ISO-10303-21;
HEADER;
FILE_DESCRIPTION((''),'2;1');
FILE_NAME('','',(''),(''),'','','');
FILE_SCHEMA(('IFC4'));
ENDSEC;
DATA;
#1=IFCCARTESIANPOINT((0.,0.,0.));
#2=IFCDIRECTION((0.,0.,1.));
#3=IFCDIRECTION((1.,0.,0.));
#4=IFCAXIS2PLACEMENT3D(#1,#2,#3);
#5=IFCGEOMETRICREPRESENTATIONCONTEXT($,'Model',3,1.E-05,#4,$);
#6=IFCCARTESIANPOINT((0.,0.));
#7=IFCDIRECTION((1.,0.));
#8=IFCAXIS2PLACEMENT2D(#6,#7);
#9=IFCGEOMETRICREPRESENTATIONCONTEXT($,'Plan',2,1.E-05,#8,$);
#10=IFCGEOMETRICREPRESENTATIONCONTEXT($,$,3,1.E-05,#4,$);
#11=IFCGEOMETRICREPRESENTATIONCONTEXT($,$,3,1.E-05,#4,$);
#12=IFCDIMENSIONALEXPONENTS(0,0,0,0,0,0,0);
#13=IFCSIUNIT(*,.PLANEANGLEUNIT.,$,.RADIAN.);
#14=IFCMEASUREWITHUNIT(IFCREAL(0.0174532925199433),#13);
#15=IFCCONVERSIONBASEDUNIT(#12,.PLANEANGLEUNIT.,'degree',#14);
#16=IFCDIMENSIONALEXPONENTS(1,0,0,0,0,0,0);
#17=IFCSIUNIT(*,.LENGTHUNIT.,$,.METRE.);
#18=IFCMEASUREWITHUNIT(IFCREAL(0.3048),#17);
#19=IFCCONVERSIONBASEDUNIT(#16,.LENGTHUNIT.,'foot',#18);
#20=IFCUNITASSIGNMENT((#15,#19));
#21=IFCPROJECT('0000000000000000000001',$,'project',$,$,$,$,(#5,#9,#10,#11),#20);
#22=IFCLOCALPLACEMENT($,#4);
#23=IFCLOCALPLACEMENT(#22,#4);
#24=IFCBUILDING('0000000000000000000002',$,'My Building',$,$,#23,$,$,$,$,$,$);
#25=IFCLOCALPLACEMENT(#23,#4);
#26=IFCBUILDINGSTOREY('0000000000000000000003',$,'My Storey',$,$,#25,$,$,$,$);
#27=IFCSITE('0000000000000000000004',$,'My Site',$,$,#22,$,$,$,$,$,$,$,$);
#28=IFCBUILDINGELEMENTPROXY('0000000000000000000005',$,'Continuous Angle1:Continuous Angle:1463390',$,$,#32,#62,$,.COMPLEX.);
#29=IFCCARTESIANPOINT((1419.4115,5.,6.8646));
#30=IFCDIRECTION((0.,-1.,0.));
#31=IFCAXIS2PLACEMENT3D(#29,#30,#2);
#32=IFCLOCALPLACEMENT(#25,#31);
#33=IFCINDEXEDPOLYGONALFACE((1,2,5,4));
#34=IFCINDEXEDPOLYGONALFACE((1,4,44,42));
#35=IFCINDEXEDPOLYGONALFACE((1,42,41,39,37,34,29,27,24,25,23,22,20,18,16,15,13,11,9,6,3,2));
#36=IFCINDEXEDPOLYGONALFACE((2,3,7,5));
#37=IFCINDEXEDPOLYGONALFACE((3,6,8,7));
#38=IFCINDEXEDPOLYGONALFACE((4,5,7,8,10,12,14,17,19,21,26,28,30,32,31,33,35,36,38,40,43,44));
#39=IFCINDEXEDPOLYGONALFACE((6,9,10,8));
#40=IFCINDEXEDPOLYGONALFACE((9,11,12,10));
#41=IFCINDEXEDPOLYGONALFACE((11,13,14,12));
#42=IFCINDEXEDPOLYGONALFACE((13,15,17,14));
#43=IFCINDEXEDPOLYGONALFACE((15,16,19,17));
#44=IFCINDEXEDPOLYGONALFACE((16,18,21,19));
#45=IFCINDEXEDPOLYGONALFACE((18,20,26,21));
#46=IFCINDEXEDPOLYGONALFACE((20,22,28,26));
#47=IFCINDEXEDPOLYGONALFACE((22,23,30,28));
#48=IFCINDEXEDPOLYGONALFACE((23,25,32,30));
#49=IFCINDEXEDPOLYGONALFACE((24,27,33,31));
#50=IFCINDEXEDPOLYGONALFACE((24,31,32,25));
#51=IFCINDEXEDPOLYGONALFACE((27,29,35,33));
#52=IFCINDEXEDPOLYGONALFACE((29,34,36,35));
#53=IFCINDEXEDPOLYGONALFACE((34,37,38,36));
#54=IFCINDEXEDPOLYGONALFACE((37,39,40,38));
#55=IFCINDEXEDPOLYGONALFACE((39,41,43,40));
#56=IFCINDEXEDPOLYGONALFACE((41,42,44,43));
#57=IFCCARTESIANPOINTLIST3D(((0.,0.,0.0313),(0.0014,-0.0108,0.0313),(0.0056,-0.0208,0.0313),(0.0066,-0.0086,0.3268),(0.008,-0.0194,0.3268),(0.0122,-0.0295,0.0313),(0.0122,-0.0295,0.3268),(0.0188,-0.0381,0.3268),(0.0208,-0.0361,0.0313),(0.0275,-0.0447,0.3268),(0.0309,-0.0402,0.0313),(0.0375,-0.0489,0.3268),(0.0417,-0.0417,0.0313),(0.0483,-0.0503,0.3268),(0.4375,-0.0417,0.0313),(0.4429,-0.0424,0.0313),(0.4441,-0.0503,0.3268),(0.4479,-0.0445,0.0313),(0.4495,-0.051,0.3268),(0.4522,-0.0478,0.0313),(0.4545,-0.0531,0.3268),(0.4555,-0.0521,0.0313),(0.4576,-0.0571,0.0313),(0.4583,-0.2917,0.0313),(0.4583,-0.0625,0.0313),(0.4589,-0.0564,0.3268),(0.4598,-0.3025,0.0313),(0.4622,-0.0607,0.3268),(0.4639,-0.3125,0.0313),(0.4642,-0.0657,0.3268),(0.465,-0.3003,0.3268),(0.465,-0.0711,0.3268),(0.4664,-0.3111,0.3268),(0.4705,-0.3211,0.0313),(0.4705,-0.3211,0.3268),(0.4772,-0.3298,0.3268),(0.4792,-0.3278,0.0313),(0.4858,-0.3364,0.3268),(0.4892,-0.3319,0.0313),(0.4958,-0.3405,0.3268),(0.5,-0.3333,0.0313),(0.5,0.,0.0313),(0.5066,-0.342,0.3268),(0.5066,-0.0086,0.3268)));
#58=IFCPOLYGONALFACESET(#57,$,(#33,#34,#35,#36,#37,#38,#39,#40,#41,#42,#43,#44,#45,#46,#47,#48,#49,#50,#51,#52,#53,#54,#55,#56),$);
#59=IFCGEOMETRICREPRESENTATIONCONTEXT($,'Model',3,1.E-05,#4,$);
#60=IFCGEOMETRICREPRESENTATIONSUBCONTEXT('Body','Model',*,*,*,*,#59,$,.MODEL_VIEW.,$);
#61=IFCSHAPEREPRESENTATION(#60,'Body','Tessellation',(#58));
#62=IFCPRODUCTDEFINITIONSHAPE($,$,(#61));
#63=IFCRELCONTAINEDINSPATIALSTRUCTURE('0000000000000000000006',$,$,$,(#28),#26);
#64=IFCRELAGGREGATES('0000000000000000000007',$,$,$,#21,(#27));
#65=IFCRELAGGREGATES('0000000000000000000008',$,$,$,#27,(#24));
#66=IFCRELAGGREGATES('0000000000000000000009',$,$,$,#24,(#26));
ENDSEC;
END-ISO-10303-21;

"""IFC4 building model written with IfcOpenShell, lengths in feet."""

from ifc_helpers import new_model, entity, si_unit, converted_unit, frame, origin_with_axes, origin_2d_with_axis, place, context, subcontext, project, spatial, polyline, outline, extrude, element, save


model = new_model("IFC4")

# Units and contexts
model_context_1 = context("Model", 3, precision=1e-05, world=origin_with_axes())
plan_context = context("Plan", 2, precision=1e-05, world=origin_2d_with_axis())
model_context_2 = context("Model", 3, precision=1e-05, world=origin_with_axes())
context_of_model_1 = context(None, 3, precision=1e-05, world=origin_with_axes())
context_of_model_2 = context(None, 3, precision=1e-05, world=origin_with_axes())
body_context_1 = subcontext(model_context_2, "Body", "Model", "MODEL_VIEW")
ifc_project = project(units=[converted_unit("PLANEANGLEUNIT", "degree", entity("IfcReal", 0.0174532925199433), si_unit("PLANEANGLEUNIT", "RADIAN"), dimensions=[0, 0, 0, 0, 0, 0, 0]), converted_unit("LENGTHUNIT", "foot", entity("IfcReal", 0.3048), si_unit("LENGTHUNIT", "METRE"), dimensions=[1, 0, 0, 0, 0, 0, 0])], contexts=[model_context_1, plan_context, context_of_model_1, context_of_model_2])

# Site, building, storey
site_placement = place(None, origin_with_axes())
site = spatial("IfcSite", under=ifc_project, at=site_placement, Name="My Site")
building_placement = place(site_placement, origin_with_axes())
building = spatial("IfcBuilding", under=site, at=building_placement, Name="My Building")
storey_placement = place(building_placement, origin_with_axes())
storey = spatial("IfcBuildingStorey", under=building, at=storey_placement, Name="My Storey")

# Building element proxy
proxy_1_placement = place(storey_placement, frame((1419.4115, 5.0, 6.8646), z_axis=(0.0, -1.0, 0.0), x_axis=(0.0, 0.0, 1.0)))
element("IfcBuildingElementProxy", 1, at=proxy_1_placement, inside=storey, Name="Continuous Angle1:Continuous Angle:1463390", PredefinedType="COMPLEX", context=body_context_1, shape_type="SweptSolid", body=[
    extrude(outline(polyline([(0.2352, 0.0), (0.2247, -0.0027), (0.2152, -0.0081), (0.0324, -0.1463), (0.0277, -0.149), (0.0224, -0.1504), (0.017, -0.1503), (0.0117, -0.1489), (0.007, -0.1461), (0.0032, -0.1423), (-0.2355, 0.1735), (-0.2431, 0.1812), (-0.2525, 0.1867), (-0.263, 0.1896), (-0.2739, 0.1897), (-0.2844, 0.1869), (-0.2939, 0.1816), (0.0077, -0.2173), (0.2736, -0.0162), (0.2659, -0.0085), (0.2566, -0.003), (0.2461, -0.0001), (0.2352, 0.0)])), frame((0.3221, -0.1249, 0.0313), z_axis=(0.0, 0.0, -1.0), x_axis=(0.60311, -0.797658, 0.0)), (0.036779, -0.000261, -0.999323), 0.2957),
])

save(model, "model.ifc")
